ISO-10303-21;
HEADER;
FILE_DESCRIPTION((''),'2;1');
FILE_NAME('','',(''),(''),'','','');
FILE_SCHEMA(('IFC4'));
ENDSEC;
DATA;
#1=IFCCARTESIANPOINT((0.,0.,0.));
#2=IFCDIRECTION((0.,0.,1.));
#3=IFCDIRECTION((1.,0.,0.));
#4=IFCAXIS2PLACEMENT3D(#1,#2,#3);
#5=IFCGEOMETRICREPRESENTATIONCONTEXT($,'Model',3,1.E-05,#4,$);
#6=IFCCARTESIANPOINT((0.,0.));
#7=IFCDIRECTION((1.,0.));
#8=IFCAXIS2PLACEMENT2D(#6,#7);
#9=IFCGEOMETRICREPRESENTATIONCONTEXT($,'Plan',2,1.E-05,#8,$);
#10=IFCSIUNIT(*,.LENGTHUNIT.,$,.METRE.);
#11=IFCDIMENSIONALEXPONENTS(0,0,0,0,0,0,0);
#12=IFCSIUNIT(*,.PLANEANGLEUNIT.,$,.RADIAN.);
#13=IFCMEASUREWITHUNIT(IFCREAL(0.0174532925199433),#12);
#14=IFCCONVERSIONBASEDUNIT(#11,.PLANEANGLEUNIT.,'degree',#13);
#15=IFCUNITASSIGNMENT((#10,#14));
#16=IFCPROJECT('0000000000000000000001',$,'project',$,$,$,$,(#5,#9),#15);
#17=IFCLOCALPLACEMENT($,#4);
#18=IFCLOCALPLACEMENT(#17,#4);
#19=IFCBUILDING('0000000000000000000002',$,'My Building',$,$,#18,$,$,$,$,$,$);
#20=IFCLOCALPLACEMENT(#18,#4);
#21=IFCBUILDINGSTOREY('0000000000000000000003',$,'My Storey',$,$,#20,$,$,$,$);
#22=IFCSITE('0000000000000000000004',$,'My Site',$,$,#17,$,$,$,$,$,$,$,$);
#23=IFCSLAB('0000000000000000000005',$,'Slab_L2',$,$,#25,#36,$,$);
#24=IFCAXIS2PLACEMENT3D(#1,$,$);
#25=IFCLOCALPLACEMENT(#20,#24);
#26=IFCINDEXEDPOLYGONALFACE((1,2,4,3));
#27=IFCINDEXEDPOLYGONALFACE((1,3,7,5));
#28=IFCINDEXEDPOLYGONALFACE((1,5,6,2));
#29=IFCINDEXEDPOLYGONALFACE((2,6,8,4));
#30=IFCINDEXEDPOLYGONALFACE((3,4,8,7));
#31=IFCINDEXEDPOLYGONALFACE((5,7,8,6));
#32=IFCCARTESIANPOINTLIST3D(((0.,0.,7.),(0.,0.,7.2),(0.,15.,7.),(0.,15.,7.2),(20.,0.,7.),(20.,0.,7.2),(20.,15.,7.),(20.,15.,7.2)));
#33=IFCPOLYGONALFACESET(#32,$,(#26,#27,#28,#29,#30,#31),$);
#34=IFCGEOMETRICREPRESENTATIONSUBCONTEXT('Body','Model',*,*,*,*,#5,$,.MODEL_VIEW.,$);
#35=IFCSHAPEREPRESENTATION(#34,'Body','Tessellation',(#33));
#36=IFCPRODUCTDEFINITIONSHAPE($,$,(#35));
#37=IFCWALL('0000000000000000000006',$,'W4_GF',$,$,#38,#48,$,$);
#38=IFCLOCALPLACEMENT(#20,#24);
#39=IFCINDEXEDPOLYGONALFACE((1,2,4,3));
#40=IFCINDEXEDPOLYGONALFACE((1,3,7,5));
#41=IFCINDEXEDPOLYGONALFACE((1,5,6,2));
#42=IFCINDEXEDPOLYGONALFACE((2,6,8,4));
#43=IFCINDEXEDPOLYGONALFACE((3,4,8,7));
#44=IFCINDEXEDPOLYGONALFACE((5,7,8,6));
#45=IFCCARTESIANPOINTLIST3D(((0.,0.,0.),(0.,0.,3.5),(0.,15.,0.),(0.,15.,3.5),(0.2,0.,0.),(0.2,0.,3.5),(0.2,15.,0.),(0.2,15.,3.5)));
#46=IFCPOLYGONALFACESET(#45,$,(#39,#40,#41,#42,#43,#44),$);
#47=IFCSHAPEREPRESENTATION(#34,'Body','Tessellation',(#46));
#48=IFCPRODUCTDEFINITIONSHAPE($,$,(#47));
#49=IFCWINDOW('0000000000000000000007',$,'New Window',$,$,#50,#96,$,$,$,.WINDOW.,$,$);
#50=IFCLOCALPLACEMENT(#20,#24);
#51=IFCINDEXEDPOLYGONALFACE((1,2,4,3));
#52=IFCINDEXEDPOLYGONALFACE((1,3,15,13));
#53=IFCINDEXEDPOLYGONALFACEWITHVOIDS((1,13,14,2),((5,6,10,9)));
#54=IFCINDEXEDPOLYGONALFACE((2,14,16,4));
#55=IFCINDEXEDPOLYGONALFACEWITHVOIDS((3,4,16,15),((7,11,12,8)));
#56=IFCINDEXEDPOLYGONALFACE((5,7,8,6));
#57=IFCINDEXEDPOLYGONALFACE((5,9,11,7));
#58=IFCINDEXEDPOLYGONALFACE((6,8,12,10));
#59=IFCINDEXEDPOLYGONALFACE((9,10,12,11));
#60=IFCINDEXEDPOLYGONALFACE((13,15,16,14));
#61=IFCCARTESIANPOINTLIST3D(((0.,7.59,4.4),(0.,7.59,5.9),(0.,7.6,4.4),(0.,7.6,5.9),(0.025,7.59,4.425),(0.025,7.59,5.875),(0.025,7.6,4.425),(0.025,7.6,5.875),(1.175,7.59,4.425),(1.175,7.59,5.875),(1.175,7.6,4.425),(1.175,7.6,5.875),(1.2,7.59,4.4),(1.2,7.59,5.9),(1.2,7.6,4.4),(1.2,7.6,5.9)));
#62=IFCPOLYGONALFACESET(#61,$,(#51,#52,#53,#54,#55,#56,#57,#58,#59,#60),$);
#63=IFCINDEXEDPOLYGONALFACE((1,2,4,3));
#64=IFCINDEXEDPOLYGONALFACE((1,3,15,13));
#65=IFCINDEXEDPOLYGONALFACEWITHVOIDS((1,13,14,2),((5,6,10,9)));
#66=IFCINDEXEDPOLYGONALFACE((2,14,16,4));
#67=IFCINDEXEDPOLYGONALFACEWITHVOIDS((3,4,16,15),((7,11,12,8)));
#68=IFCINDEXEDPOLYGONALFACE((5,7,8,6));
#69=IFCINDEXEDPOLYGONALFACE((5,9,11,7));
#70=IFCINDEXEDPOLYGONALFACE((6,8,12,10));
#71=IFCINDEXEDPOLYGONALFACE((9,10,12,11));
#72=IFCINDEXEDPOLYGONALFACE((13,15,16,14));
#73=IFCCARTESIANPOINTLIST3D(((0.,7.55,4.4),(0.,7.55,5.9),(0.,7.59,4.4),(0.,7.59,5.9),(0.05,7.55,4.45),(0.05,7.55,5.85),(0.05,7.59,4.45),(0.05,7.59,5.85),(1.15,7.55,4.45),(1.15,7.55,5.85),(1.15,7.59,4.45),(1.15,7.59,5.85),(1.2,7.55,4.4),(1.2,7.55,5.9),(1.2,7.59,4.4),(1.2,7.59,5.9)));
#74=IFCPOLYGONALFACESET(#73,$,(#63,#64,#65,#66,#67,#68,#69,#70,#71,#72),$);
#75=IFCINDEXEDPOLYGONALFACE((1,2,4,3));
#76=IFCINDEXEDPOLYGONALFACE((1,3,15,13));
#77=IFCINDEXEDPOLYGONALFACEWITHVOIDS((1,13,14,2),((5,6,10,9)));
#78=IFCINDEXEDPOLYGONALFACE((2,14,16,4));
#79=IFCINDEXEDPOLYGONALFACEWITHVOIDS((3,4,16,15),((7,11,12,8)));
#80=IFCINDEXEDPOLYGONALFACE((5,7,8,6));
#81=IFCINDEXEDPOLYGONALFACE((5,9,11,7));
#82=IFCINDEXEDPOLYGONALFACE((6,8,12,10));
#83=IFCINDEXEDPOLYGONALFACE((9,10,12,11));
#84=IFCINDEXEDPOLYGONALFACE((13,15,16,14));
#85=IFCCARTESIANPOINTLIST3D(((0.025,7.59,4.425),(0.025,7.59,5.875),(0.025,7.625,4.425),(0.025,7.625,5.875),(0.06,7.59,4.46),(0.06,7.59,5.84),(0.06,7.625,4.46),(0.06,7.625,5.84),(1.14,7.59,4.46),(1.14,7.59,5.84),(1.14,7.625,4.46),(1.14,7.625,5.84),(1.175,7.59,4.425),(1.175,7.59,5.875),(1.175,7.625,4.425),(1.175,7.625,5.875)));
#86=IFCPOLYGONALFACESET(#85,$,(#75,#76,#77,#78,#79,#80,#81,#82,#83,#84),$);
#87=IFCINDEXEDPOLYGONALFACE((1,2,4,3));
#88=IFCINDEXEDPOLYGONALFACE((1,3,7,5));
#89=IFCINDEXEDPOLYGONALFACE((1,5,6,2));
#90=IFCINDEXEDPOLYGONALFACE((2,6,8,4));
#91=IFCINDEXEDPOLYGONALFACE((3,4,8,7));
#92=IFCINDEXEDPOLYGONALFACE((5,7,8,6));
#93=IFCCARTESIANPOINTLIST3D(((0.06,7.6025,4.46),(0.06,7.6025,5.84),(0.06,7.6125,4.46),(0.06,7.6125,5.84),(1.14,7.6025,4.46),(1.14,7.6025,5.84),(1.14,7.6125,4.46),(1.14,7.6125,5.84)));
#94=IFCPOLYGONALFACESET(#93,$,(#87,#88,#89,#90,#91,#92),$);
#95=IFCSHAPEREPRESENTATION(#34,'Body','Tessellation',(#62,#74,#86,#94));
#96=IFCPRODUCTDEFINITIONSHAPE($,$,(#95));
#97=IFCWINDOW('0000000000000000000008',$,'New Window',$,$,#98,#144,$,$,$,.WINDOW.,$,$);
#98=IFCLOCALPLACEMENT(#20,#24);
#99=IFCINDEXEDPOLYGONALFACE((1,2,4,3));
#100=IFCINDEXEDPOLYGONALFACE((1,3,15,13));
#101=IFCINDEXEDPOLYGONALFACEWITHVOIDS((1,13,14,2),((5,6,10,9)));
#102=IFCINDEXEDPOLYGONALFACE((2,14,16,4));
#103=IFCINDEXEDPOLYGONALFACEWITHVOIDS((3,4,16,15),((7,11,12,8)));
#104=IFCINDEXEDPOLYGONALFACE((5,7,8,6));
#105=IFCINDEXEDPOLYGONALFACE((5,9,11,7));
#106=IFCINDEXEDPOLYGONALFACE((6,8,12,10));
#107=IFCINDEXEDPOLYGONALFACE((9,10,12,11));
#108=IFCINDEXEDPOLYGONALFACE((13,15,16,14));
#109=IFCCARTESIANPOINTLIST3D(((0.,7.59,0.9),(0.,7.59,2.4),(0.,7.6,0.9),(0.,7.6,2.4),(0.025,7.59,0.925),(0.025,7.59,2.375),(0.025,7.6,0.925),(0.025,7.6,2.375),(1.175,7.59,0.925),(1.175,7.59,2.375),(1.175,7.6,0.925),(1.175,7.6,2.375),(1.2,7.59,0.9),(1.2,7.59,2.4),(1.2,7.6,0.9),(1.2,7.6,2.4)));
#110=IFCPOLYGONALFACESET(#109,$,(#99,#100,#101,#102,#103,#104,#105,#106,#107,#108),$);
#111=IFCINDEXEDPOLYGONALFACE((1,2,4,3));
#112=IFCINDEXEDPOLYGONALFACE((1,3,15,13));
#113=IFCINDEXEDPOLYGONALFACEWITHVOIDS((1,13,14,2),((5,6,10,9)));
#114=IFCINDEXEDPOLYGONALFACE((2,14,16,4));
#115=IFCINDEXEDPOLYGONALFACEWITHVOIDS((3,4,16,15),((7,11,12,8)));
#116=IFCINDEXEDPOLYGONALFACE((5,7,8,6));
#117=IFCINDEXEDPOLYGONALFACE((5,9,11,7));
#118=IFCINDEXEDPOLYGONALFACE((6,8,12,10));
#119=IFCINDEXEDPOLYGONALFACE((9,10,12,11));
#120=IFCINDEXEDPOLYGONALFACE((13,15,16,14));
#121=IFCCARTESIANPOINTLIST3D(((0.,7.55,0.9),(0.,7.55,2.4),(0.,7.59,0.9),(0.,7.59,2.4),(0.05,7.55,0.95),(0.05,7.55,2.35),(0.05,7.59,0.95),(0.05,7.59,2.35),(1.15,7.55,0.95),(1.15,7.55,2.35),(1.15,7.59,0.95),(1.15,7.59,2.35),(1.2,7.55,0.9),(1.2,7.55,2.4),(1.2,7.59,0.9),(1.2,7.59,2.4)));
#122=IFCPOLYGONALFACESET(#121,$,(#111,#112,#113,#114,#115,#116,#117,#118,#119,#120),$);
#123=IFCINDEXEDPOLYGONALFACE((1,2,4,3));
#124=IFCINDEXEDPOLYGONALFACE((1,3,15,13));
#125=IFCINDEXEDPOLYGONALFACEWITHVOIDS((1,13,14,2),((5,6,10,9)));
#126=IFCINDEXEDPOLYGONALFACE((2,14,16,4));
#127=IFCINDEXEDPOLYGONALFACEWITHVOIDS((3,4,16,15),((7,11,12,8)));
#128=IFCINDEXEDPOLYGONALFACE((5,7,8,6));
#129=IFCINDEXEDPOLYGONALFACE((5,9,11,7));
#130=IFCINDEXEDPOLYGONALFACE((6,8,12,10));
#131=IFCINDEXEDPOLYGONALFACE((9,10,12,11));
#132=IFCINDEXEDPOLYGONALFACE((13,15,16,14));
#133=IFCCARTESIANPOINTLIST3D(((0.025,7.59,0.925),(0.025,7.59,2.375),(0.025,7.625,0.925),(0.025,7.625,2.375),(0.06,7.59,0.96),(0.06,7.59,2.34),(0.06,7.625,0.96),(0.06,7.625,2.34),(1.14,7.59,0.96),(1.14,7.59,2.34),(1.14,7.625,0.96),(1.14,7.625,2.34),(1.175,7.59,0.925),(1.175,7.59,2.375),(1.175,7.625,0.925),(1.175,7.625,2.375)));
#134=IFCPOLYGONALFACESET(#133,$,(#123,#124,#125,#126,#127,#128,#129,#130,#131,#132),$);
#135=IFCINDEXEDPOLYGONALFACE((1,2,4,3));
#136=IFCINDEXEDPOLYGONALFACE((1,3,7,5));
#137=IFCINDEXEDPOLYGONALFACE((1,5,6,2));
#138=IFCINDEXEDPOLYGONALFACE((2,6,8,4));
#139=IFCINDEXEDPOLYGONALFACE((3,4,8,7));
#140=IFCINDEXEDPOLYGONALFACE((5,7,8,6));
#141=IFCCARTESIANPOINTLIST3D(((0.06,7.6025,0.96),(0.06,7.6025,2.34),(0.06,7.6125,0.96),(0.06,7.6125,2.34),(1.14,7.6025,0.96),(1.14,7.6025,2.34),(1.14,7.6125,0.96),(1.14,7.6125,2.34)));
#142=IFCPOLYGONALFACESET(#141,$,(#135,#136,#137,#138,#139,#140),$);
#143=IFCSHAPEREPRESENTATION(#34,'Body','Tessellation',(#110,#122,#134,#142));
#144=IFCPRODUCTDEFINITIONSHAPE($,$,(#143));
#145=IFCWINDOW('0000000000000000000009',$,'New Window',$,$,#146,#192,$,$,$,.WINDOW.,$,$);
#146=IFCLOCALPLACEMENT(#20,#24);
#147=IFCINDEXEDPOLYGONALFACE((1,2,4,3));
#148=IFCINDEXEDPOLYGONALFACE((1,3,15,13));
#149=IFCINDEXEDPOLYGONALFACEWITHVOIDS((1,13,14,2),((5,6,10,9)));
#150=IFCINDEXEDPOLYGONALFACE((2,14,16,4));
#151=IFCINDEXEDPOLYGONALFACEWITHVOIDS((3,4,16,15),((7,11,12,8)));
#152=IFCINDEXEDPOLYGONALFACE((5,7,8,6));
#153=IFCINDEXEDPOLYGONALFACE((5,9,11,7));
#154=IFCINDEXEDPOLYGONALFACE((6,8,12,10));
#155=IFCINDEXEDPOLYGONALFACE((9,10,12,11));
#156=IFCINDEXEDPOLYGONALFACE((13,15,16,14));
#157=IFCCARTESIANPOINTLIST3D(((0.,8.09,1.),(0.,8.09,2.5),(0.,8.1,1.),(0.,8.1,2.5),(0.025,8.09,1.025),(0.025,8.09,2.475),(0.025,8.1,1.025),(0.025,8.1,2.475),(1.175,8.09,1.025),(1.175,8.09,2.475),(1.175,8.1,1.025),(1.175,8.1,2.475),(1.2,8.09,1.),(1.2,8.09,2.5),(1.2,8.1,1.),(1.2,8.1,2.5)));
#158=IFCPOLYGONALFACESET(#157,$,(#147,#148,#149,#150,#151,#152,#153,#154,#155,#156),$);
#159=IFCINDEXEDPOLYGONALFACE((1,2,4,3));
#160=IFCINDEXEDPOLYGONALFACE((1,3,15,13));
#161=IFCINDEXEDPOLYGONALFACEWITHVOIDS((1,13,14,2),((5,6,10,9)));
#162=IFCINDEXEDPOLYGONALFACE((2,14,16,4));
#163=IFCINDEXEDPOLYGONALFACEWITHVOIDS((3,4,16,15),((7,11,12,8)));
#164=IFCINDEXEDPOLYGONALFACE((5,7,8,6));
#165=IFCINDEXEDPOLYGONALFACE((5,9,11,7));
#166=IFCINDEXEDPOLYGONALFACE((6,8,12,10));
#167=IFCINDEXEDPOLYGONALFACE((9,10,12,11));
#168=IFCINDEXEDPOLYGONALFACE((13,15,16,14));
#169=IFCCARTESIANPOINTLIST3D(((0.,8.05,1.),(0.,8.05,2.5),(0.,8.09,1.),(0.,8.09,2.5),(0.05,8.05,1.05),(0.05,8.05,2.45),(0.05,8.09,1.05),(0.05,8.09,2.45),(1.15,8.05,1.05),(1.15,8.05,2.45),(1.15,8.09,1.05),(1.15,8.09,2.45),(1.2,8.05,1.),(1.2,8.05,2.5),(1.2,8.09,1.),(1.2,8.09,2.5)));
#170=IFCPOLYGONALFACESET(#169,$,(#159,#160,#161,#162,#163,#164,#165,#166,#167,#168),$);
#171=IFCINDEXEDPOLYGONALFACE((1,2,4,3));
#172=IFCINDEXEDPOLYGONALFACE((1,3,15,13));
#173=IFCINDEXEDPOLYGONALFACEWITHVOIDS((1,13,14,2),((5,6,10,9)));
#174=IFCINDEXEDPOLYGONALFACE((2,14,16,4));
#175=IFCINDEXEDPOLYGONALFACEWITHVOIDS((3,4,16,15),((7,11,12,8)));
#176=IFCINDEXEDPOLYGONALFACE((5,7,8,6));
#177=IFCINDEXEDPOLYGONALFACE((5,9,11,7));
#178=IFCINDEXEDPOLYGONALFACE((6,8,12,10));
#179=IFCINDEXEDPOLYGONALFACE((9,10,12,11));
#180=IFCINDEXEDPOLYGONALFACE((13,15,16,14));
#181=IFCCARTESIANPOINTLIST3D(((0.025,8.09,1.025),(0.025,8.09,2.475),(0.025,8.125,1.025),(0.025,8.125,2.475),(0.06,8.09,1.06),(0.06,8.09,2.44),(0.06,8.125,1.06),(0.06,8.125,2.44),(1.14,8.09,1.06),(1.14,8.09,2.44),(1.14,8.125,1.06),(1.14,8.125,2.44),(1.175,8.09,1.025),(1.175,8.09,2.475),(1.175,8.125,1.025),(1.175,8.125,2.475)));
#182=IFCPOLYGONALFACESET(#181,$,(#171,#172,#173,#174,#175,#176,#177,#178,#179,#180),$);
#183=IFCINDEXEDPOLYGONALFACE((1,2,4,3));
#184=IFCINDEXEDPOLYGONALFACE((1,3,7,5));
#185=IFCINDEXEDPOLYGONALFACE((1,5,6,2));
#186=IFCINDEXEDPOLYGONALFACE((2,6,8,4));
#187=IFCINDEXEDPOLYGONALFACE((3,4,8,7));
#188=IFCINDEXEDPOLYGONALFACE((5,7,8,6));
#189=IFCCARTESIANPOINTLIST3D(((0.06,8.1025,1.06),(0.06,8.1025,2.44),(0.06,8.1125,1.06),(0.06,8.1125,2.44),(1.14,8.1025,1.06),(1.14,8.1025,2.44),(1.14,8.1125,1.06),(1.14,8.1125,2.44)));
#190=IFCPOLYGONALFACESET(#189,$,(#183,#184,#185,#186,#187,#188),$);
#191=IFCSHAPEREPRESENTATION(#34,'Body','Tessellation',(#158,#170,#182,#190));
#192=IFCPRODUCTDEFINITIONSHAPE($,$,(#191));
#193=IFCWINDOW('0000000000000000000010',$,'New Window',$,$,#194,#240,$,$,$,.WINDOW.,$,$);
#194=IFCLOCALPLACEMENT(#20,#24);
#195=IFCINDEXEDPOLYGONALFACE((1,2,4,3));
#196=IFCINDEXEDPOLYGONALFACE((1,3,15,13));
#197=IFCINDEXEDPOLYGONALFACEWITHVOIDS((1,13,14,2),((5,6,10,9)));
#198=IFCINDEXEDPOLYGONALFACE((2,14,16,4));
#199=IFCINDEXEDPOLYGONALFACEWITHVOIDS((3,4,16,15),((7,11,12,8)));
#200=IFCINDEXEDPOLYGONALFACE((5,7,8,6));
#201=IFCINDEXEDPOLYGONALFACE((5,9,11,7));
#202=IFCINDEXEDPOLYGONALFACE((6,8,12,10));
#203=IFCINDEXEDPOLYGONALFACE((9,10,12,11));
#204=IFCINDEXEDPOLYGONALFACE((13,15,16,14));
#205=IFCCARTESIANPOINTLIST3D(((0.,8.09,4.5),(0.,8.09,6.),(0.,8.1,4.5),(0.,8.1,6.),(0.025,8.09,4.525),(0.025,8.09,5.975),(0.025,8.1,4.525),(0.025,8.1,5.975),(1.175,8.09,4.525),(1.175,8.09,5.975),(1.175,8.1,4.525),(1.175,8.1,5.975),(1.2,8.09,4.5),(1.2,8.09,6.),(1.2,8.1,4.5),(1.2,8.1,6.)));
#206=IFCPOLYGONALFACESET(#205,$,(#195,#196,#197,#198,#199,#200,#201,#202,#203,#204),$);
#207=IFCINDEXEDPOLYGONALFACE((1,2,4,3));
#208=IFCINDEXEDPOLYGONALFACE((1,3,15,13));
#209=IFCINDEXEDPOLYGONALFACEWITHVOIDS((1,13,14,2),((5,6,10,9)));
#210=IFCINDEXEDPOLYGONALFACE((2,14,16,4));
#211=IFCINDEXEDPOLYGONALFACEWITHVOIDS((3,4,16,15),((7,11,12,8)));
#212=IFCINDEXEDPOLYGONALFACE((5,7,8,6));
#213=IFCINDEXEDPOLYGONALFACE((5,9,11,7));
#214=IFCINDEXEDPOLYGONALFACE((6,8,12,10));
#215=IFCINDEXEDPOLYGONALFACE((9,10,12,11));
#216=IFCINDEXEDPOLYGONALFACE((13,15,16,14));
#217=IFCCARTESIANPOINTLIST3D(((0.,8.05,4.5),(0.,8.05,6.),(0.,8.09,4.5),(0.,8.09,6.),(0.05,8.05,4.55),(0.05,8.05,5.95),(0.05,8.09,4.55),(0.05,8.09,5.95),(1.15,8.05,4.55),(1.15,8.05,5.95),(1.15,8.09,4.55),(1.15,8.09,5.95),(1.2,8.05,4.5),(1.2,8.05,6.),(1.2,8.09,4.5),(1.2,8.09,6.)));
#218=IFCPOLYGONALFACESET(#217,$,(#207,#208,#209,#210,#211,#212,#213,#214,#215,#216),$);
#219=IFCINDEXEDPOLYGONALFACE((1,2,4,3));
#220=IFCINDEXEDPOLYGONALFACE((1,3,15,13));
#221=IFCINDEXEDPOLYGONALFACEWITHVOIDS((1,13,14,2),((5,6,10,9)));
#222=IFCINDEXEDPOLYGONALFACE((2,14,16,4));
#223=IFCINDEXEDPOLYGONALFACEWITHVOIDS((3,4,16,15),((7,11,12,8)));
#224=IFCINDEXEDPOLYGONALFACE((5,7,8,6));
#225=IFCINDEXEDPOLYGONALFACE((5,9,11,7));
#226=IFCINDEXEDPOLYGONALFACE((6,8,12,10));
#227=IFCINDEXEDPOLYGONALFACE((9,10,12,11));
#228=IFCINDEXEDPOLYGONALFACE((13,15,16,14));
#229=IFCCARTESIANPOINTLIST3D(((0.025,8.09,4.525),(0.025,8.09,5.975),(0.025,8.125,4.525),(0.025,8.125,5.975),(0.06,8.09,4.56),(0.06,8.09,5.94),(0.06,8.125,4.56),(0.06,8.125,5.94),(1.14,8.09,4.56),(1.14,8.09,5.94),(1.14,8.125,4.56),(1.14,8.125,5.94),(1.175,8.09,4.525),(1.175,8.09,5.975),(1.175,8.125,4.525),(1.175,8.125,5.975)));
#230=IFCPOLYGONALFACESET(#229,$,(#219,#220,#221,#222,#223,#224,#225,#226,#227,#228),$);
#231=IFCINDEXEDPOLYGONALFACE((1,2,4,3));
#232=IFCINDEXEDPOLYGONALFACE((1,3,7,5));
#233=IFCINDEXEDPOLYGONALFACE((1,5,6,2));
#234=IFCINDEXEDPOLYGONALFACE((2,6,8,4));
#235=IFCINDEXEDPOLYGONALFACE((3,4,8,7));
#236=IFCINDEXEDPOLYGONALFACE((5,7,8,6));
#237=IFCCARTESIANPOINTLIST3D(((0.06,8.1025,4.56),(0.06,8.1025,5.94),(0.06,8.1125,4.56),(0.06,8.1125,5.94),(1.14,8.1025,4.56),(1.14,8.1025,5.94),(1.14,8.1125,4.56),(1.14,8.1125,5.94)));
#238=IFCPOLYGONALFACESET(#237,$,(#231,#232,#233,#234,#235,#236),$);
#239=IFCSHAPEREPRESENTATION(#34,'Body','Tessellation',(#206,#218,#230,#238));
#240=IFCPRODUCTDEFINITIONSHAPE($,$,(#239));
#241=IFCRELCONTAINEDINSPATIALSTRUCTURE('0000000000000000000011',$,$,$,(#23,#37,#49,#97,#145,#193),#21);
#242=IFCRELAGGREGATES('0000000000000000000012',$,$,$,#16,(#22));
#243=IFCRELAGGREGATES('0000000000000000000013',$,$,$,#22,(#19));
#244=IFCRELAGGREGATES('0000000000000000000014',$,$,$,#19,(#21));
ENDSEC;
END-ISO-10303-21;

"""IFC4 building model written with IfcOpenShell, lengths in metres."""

from ifc_helpers import new_model, entity, si_unit, converted_unit, frame, origin_with_axes, origin_2d_with_axis, place, context, subcontext, project, spatial, line, indexed_curve, outline, extrude, element, save


model = new_model("IFC4")

# Units and contexts
model_context = context("Model", 3, precision=1e-05, world=origin_with_axes())
plan_context = context("Plan", 2, precision=1e-05, world=origin_2d_with_axis())
body_context = subcontext(model_context, "Body", "Model", "MODEL_VIEW")
ifc_project = project(units=[si_unit("LENGTHUNIT", "METRE"), converted_unit("PLANEANGLEUNIT", "degree", entity("IfcReal", 0.0174532925199433), si_unit("PLANEANGLEUNIT", "RADIAN"), dimensions=[0, 0, 0, 0, 0, 0, 0])], contexts=[model_context, plan_context])

# Site, building, storey
site_placement = place(None, origin_with_axes())
site = spatial("IfcSite", under=ifc_project, at=site_placement, Name="My Site")
building_placement = place(site_placement, origin_with_axes())
building = spatial("IfcBuilding", under=site, at=building_placement, Name="My Building")
storey_placement = place(building_placement, origin_with_axes())
storey = spatial("IfcBuildingStorey", under=building, at=storey_placement, Name="My Storey")

# Slab
slab_placement = place(storey_placement, frame((0.0, 0.0, 7.0), z_axis=(0.0, 0.0, 1.0), x_axis=(1.0, 0.0, 0.0)))
element("IfcSlab", 1, at=slab_placement, inside=storey, Name="Slab_L2", context=body_context, shape_type="SweptSolid", body=[
    extrude(outline(indexed_curve([(0.0, 0.0), (20.0, 0.0), (20.0, 15.0), (0.0, 15.0), (0.0, 0.0)])), None, (0.0, 0.0, 1.0), 0.2),
])

# Wall
wall_1_placement = place(storey_placement, frame((0.0, 15.0, 0.0), z_axis=(0.0, 0.0, 1.0), x_axis=(0.0, -1.0, 0.0)))
element("IfcWall", 2, at=wall_1_placement, inside=storey, Name="W4_GF", context=body_context, shape_type="SweptSolid", body=[
    extrude(outline(indexed_curve([(0.0, 0.0), (0.0, 0.2), (15.0, 0.2), (15.0, 0.0), (0.0, 0.0)], self_intersect=False)), origin_with_axes(), (0.0, 0.0, 1.0), 3.5),
])

# Windows
for number, where, z_axis, x_axis, name in (
    (3, (0.0, 7.5, 4.4), (0.0, 0.0, 1.0), (1.0, 0.0, 0.0), "New Window"),
    (4, (0.0, 7.5, 0.9), (0.0, 0.0, 1.0), (1.0, 0.0, 0.0), "New Window"),
    (5, (0.0, 8.0, 1.0), (0.0, 0.0, 1.0), (1.0, 0.0, 0.0), "New Window"),
    (6, (0.0, 8.0, 4.5), (0.0, 0.0, 1.0), (1.0, 0.0, 0.0), "New Window"),
):
    element("IfcWindow", number, at=place(storey_placement, frame(where, z_axis=z_axis, x_axis=x_axis)), inside=storey, Name=name, PredefinedType="WINDOW", context=body_context, shape_type="SweptSolid", body=[
        extrude(outline(indexed_curve([(0.0, 0.0), (1.2, 0.0), (1.2, 1.5), (0.0, 1.5)], segments=[line(1, 2, 3, 4, 1)]), holes=[indexed_curve([(0.025, 0.025), (1.175, 0.025), (1.175, 1.475), (0.025, 1.475)], segments=[line(1, 2, 3, 4, 1)])]), frame((0.0, 0.09, 0.0), z_axis=(0.0, -1.0, 0.0), x_axis=(1.0, 0.0, 0.0)), (0.0, 0.0, -1.0), 0.01),
        extrude(outline(indexed_curve([(0.0, 0.0), (1.2, 0.0), (1.2, 1.5), (0.0, 1.5)], segments=[line(1, 2, 3, 4, 1)]), holes=[indexed_curve([(0.05, 0.05), (1.15, 0.05), (1.15, 1.45), (0.05, 1.45)], segments=[line(1, 2, 3, 4, 1)])]), frame((0.0, 0.05, 0.0), z_axis=(0.0, -1.0, 0.0), x_axis=(1.0, 0.0, 0.0)), (0.0, 0.0, -1.0), 0.04),
        extrude(outline(indexed_curve([(0.0, 0.0), (1.15, 0.0), (1.15, 1.45), (0.0, 1.45)], segments=[line(1, 2, 3, 4, 1)]), holes=[indexed_curve([(0.035, 0.035), (1.115, 0.035), (1.115, 1.415), (0.035, 1.415)], segments=[line(1, 2, 3, 4, 1)])]), frame((0.025, 0.09, 0.025), z_axis=(0.0, -1.0, 0.0), x_axis=(1.0, 0.0, 0.0)), (0.0, 0.0, -1.0), 0.035),
        extrude(outline(indexed_curve([(0.035, 0.035), (1.115, 0.035), (1.115, 1.415), (0.035, 1.415)], segments=[line(1, 2, 3, 4, 1)])), frame((0.025, 0.1025, 0.025), z_axis=(0.0, -1.0, 0.0), x_axis=(1.0, 0.0, 0.0)), (0.0, 0.0, -1.0), 0.01),
    ])

save(model, "model.ifc")
